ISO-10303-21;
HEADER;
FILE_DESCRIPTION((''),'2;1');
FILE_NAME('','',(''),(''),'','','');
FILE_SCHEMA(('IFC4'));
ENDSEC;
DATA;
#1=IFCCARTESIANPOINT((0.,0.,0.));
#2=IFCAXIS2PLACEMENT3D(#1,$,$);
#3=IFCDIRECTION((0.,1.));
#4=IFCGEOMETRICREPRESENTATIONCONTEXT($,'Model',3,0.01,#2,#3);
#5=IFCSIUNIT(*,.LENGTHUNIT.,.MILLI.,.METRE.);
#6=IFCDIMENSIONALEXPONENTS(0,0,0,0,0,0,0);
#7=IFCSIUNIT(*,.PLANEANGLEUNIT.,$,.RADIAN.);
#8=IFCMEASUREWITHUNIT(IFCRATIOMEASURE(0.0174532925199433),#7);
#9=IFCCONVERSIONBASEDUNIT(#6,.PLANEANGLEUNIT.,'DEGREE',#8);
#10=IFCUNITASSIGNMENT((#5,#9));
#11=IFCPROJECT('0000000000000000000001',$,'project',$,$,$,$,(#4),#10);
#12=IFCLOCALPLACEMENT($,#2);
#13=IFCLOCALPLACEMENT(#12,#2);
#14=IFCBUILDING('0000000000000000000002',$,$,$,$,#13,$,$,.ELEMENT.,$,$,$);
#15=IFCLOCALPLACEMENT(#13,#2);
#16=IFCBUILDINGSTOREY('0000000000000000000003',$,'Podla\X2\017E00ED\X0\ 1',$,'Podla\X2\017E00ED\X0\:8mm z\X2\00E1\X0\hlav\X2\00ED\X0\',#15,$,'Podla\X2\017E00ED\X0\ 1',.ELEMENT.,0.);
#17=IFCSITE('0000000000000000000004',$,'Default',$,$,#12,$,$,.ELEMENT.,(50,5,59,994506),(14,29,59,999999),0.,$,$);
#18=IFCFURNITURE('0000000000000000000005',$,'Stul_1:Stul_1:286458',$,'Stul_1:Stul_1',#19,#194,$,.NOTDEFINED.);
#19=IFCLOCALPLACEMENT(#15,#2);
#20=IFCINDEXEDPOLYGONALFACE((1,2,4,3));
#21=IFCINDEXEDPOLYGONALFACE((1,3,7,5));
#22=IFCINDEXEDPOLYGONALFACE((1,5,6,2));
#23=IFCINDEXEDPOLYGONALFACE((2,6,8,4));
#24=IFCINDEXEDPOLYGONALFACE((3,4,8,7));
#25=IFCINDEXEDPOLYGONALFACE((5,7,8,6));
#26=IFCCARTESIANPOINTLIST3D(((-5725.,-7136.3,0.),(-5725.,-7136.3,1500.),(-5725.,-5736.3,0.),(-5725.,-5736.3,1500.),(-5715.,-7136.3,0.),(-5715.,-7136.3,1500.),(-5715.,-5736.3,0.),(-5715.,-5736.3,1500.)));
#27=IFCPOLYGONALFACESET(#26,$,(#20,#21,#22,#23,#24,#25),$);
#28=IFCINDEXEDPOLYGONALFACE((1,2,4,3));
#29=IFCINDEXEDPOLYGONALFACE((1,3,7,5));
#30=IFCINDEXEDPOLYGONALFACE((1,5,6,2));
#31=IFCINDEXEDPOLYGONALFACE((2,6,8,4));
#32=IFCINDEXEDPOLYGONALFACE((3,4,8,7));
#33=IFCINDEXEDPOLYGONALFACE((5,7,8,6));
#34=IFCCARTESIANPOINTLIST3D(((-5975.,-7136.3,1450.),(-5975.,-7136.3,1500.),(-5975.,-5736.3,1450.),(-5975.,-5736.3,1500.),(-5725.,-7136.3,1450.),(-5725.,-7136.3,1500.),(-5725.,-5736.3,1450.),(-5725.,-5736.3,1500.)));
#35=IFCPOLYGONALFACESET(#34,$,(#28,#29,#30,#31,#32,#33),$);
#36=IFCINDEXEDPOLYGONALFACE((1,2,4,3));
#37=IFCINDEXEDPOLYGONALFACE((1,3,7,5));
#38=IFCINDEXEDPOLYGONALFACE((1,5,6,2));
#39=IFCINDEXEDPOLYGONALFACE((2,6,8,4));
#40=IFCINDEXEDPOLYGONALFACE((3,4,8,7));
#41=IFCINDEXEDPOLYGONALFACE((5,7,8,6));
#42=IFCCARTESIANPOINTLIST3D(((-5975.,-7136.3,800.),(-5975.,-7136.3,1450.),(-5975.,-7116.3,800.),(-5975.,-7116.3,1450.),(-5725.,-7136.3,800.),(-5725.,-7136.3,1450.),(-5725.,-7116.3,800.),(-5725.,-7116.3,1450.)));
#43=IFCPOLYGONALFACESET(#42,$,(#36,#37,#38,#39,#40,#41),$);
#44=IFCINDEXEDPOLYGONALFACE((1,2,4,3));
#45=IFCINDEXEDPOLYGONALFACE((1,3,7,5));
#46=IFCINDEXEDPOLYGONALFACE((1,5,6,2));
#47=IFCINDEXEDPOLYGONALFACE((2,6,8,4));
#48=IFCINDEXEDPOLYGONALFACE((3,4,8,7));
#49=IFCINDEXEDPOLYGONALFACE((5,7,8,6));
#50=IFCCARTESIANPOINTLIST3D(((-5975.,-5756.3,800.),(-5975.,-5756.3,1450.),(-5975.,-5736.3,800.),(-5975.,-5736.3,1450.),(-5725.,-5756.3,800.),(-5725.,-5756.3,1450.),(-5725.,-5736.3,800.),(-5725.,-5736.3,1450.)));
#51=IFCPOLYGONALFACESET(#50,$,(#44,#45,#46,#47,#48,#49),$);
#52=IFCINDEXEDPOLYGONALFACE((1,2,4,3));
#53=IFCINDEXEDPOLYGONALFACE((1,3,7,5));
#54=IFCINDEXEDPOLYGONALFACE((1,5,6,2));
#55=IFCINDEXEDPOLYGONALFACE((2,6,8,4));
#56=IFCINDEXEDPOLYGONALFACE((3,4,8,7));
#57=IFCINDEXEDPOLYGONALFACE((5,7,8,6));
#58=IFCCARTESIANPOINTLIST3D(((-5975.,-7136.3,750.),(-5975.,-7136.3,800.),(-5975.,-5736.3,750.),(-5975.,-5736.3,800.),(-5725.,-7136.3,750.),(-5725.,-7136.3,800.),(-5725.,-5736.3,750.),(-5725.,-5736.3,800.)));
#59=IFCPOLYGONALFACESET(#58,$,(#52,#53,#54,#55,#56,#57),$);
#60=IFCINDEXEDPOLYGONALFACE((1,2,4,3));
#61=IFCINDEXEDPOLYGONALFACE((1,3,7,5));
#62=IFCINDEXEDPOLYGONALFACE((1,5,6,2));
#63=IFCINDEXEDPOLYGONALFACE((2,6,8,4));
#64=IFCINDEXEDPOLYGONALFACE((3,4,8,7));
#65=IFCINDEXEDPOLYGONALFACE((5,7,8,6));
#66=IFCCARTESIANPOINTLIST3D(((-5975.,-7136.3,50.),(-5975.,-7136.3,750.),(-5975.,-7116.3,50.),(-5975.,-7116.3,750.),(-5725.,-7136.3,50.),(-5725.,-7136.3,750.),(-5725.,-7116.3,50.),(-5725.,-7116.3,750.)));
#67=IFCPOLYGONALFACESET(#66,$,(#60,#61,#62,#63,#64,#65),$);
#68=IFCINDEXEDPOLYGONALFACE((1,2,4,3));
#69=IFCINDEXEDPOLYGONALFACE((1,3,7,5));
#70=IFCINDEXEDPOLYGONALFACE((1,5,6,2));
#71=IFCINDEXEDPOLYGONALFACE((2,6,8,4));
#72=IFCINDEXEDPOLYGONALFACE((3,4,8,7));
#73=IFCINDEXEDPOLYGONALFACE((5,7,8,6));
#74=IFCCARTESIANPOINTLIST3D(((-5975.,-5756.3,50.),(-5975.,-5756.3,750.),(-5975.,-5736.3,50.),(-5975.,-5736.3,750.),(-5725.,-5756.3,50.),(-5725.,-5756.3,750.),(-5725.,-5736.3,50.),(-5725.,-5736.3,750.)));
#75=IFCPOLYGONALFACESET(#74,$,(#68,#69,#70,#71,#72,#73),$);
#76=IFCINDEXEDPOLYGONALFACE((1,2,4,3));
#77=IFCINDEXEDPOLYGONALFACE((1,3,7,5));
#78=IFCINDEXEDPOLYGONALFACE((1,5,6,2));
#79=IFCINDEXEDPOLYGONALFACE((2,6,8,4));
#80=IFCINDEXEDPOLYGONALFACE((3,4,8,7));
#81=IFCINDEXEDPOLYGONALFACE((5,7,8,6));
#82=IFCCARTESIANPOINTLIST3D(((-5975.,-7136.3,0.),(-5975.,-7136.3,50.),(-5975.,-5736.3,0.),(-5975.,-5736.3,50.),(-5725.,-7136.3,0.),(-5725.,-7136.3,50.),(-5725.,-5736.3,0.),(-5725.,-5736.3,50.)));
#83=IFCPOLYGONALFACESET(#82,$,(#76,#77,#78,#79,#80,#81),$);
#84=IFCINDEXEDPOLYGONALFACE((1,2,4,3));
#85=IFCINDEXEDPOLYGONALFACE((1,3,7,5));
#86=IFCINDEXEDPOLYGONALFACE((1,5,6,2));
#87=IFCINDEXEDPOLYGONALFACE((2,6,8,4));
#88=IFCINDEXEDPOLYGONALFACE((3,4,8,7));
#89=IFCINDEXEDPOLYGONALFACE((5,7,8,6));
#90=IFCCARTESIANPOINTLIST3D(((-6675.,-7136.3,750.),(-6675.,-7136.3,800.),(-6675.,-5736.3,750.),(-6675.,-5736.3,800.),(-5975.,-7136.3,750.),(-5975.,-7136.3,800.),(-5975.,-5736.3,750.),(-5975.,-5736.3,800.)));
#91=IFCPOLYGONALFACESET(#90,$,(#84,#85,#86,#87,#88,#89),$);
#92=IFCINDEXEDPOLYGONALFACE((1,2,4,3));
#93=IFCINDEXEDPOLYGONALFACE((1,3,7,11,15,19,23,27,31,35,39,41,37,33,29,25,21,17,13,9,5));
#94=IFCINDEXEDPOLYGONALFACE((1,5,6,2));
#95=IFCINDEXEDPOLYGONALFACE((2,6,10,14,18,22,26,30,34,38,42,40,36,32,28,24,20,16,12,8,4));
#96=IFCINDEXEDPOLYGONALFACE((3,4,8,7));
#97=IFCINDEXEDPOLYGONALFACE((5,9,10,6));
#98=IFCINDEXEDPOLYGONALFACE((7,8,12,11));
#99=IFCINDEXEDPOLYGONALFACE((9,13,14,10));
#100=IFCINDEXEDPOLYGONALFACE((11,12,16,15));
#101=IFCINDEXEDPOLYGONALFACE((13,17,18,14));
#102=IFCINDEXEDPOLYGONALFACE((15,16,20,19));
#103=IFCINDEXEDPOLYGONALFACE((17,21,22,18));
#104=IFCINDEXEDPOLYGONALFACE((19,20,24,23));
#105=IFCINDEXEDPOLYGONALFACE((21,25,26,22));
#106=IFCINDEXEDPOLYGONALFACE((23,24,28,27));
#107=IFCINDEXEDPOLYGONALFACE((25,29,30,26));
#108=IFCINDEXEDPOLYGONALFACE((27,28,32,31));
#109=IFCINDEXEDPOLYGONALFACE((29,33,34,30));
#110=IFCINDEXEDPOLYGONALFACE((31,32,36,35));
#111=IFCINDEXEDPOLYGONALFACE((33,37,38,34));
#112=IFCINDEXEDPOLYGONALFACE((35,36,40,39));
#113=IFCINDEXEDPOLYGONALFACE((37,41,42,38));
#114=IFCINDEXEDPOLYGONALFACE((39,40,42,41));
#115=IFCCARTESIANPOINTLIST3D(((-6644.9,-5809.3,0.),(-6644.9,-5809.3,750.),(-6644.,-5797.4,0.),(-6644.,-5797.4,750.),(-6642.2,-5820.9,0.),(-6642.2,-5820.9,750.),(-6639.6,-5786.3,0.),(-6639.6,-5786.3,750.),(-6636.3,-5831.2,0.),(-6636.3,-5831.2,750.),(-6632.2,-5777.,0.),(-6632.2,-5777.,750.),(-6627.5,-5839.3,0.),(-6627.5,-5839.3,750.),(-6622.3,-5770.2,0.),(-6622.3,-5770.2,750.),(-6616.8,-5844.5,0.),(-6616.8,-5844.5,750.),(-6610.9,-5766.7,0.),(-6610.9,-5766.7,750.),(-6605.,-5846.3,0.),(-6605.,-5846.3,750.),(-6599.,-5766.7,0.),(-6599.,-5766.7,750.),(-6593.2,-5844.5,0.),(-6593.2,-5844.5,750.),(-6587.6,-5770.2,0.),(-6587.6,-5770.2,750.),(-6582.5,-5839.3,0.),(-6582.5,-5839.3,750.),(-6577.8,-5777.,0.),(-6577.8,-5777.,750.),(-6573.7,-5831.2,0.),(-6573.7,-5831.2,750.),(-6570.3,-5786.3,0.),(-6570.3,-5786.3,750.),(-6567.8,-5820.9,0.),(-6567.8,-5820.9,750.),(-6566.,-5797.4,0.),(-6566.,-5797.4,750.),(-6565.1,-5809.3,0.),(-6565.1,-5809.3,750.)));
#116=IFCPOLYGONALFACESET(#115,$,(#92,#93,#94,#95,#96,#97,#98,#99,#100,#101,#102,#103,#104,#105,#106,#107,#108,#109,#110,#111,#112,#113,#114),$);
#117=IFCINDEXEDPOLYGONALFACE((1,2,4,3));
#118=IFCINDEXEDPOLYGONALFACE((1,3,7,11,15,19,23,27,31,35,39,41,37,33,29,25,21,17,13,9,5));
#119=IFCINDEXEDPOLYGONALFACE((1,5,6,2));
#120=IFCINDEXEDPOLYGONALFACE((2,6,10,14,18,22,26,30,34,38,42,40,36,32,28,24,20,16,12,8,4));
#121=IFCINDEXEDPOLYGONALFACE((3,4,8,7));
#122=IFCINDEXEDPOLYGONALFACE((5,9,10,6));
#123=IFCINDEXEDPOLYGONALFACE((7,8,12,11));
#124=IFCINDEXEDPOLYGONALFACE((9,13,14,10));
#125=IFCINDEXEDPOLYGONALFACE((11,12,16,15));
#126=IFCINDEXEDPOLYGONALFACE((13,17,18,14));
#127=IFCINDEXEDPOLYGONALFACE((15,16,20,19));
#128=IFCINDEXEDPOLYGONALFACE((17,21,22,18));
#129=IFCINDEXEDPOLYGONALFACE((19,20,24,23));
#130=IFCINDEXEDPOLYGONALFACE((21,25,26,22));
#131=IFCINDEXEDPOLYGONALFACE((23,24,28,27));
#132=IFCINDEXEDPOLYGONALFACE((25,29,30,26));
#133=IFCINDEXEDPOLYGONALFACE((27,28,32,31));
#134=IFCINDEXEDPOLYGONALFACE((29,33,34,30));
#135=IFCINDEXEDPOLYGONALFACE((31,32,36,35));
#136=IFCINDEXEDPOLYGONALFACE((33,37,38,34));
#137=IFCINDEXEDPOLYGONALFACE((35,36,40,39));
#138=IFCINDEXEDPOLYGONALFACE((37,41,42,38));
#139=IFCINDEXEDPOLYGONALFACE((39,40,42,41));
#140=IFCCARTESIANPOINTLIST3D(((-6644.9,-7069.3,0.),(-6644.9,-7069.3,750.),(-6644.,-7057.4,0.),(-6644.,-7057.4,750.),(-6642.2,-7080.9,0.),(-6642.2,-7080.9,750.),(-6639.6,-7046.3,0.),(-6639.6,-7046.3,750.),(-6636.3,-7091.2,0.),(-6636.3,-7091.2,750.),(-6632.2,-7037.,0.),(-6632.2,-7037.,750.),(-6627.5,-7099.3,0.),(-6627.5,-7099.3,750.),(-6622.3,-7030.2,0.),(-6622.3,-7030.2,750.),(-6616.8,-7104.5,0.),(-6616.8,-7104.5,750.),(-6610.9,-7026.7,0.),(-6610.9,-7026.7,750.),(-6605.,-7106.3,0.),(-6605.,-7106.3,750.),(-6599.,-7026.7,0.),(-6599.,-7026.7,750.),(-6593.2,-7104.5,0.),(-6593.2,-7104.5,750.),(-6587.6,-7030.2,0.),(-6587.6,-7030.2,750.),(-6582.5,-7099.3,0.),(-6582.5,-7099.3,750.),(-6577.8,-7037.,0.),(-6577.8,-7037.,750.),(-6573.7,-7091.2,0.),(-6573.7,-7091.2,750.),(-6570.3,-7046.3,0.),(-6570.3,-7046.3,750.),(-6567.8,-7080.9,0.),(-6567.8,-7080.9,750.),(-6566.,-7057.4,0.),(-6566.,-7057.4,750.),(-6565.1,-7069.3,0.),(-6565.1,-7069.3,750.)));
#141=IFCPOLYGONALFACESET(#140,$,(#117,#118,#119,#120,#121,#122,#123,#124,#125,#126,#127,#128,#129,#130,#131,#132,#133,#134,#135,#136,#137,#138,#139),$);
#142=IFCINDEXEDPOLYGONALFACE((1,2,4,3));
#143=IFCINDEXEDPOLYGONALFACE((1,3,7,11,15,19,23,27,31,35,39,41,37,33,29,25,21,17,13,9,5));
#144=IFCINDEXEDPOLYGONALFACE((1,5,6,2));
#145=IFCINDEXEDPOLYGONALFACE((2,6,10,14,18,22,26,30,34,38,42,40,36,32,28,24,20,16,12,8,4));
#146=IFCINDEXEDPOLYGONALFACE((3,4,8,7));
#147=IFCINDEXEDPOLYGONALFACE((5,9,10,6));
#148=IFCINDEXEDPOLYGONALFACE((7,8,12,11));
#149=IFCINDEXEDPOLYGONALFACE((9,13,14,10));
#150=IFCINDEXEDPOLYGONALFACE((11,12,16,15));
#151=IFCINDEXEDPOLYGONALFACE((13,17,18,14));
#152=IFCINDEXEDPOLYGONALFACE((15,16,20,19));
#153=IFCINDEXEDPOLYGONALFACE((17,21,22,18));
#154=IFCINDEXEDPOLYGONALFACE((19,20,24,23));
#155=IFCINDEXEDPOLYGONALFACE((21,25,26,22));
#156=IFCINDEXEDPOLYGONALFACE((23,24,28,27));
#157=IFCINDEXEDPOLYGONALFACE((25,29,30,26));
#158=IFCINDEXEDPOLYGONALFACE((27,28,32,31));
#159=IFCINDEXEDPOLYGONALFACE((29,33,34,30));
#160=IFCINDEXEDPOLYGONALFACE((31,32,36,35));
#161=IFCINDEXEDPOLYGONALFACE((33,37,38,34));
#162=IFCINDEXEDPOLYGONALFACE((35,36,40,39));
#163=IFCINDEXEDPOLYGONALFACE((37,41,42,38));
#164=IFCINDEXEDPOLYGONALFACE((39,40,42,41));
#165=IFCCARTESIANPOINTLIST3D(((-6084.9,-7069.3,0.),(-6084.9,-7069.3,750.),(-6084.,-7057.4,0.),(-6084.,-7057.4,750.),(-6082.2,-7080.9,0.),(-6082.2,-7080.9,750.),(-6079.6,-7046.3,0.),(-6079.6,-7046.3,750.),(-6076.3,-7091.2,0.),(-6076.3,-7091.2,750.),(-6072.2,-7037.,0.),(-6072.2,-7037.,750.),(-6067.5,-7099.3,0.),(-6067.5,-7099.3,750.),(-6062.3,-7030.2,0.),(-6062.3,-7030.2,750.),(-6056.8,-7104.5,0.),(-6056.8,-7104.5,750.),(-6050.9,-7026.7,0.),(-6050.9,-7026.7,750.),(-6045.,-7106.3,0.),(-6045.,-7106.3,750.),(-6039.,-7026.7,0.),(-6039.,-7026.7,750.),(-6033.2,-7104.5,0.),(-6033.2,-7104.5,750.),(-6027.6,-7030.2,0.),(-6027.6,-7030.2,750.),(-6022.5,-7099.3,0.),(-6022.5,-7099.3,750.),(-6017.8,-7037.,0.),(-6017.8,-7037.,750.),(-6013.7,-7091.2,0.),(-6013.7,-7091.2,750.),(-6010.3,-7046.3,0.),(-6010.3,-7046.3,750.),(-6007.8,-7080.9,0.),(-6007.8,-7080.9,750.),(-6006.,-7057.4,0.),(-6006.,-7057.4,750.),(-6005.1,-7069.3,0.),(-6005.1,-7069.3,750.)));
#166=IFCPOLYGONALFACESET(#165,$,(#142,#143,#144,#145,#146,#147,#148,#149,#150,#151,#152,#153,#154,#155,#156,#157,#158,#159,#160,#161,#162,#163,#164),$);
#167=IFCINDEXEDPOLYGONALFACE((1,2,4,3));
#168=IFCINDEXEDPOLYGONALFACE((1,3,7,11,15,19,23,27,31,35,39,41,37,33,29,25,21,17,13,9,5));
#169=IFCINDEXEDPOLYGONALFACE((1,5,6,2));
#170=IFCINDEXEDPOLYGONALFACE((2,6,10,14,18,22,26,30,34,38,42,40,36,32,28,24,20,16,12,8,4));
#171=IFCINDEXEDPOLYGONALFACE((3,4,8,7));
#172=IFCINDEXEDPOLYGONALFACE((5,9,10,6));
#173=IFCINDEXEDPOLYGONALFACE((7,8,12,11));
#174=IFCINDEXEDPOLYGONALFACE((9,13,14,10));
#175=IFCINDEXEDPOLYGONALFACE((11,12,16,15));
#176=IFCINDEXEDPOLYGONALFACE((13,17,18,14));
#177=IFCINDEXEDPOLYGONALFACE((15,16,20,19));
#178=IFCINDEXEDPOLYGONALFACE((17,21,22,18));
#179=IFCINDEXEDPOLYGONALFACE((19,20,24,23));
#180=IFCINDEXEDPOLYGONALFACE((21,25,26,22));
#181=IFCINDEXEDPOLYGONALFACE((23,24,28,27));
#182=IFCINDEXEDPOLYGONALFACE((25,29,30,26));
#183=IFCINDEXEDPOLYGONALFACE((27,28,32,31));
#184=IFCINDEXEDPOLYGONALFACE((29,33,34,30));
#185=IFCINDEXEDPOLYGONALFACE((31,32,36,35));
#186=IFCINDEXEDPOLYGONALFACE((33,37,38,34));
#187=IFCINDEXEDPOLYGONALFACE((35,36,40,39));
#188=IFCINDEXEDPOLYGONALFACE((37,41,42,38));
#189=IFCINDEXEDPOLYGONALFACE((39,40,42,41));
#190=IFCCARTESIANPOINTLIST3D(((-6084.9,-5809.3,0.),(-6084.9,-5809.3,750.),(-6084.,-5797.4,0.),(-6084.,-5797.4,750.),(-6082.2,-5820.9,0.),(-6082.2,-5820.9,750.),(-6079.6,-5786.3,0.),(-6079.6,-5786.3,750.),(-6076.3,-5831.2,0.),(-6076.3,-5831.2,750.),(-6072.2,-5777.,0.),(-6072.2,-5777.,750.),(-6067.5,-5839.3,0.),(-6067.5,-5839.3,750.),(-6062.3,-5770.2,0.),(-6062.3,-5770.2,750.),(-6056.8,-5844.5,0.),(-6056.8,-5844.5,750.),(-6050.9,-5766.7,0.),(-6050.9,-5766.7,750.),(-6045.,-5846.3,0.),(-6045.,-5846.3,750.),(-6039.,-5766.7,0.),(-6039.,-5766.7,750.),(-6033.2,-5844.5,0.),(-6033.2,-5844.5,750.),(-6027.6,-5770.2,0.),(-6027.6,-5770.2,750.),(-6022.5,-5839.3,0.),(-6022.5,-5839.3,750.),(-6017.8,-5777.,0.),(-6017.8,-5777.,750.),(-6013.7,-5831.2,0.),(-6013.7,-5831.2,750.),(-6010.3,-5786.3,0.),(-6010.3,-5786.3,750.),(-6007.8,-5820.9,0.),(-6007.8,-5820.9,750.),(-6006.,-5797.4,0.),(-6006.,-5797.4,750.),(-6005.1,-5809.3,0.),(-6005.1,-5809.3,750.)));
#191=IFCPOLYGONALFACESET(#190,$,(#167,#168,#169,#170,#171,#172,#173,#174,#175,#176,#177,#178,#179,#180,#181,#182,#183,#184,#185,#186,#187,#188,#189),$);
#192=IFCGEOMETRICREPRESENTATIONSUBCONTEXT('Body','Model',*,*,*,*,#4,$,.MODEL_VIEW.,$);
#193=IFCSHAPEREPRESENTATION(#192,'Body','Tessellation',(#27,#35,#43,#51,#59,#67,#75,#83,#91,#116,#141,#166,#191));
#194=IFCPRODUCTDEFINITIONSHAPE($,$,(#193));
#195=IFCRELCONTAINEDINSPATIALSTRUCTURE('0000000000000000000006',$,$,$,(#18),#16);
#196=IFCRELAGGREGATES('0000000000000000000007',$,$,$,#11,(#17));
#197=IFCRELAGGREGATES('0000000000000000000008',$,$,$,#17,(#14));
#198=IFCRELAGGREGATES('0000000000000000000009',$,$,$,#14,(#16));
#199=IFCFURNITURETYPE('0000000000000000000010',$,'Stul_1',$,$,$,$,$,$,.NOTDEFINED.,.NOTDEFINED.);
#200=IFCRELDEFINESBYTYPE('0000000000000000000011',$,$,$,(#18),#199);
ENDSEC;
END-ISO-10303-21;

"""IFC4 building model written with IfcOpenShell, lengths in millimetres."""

from ifc_helpers import new_model, entity, si_unit, converted_unit, direction, frame, frame_2d, origin, origin_2d_with_axis, place, context, subcontext, project, spatial, rectangle, circle, extrude, source, transform, mapped, type_object, type_shapes, element, save


model = new_model("IFC4")

# Units and contexts
model_context = context("Model", 3, precision=0.01, world=origin(), true_north=direction((0.0, 1.0)))
body_context = subcontext(model_context, "Body", "Model", "MODEL_VIEW")
ifc_project = project(units=[si_unit("LENGTHUNIT", "METRE", prefix="MILLI"), converted_unit("PLANEANGLEUNIT", "DEGREE", entity("IfcRatioMeasure", 0.0174532925199433), si_unit("PLANEANGLEUNIT", "RADIAN"), dimensions=[0, 0, 0, 0, 0, 0, 0])], contexts=[model_context])

# Site, building, storey
site_placement = place(None, origin())
site = spatial("IfcSite", under=ifc_project, at=site_placement, Name="Default", CompositionType="ELEMENT", RefLatitude=(50, 5, 59, 994506), RefLongitude=(14, 29, 59, 999999), RefElevation=0.0)
building_placement = place(site_placement, origin())
building = spatial("IfcBuilding", under=site, at=building_placement, CompositionType="ELEMENT")
storey_placement = place(building_placement, origin())
storey = spatial("IfcBuildingStorey", under=building, at=storey_placement, Name="Podlaží 1", ObjectType="Podlaží:8mm záhlaví", LongName="Podlaží 1", CompositionType="ELEMENT", Elevation=0.0)

# Furniture
furniture_type = type_object("IfcFurnitureType", Name="Stul_1", AssemblyPlace="NOTDEFINED", PredefinedType="NOTDEFINED")
shared_shape_1 = source(origin(), body_context, "Body", "SweptSolid", [
    extrude(rectangle(XDim=1400.0, YDim=10.0, at=origin_2d_with_axis()), frame((0.0, 605.0, 0.0), z_axis=(0.0, 0.0, 1.0), x_axis=(-1.0, 0.0, 0.0)), (0.0, 0.0, 1.0), 1500.0),
    extrude(rectangle(XDim=1400.0, YDim=250.0, at=frame_2d((0.0, 0.0), x_axis=(1.0, 0.0))), frame((0.0, 475.0, 1450.0), z_axis=(0.0, 0.0, 1.0), x_axis=(-1.0, 0.0, 0.0)), (0.0, 0.0, 1.0), 50.0),
    extrude(rectangle(XDim=20.0, YDim=250.0, at=origin_2d_with_axis()), frame((690.0, 475.0, 800.0), z_axis=(0.0, 0.0, 1.0), x_axis=(-1.0, 0.0, 0.0)), (0.0, 0.0, 1.0), 650.0),
    extrude(rectangle(XDim=20.0, YDim=250.0, at=frame_2d((0.0, 0.0), x_axis=(1.0, 0.0))), frame((-690.0, 475.0, 800.0), z_axis=(0.0, 0.0, 1.0), x_axis=(-1.0, 0.0, 0.0)), (0.0, 0.0, 1.0), 650.0),
    extrude(rectangle(XDim=1400.0, YDim=250.0, at=origin_2d_with_axis()), frame((0.0, 475.0, 750.0), z_axis=(0.0, 0.0, 1.0), x_axis=(-1.0, 0.0, 0.0)), (0.0, 0.0, 1.0), 50.0),
    extrude(rectangle(XDim=20.0, YDim=250.0, at=origin_2d_with_axis()), frame((690.0, 475.0, 50.0), z_axis=(0.0, 0.0, 1.0), x_axis=(-1.0, 0.0, 0.0)), (0.0, 0.0, 1.0), 700.0),
    extrude(rectangle(XDim=20.0, YDim=250.0, at=frame_2d((0.0, 0.0), x_axis=(1.0, 0.0))), frame((-690.0, 475.0, 50.0), z_axis=(0.0, 0.0, 1.0), x_axis=(-1.0, 0.0, 0.0)), (0.0, 0.0, 1.0), 700.0),
    extrude(rectangle(XDim=1400.0, YDim=250.0, at=origin_2d_with_axis()), frame((0.0, 475.0, 0.0), z_axis=(0.0, 0.0, 1.0), x_axis=(-1.0, 0.0, 0.0)), (0.0, 0.0, 1.0), 50.0),
    extrude(rectangle(XDim=1400.0, YDim=700.0, at=origin_2d_with_axis()), frame((0.0, 0.0, 750.0), z_axis=(0.0, 0.0, 1.0), x_axis=(-1.0, 0.0, 0.0)), (0.0, 0.0, 1.0), 50.0),
    extrude(circle(Radius=40.0, at=frame_2d((0.0, 0.0), x_axis=(1.0, 0.0))), frame((-630.0, -280.0, 0.0)), (0.0, 0.0, 1.0), 750.0),
    extrude(circle(Radius=40.0, at=frame_2d((0.0, 0.0), x_axis=(1.0, 0.0))), frame((630.0, -280.0, 0.0)), (0.0, 0.0, 1.0), 750.0),
    extrude(circle(Radius=40.0, at=frame_2d((0.0, 0.0), x_axis=(1.0, 0.0))), frame((630.0, 280.0, 0.0)), (0.0, 0.0, 1.0), 750.0),
    extrude(circle(Radius=40.0, at=frame_2d((0.0, 0.0), x_axis=(1.0, 0.0))), frame((-630.0, 280.0, 0.0)), (0.0, 0.0, 1.0), 750.0),
])
type_shapes(furniture_type, [shared_shape_1])
for number, where, z_axis, x_axis, name in (
    (1, (-6325.0, -6436.3, 0.0), (0.0, 0.0, 1.0), (0.0, -1.0, 0.0), "Stul_1:Stul_1:286458"),
):
    element("IfcFurniture", number, at=place(storey_placement, frame(where, z_axis=z_axis, x_axis=x_axis)), inside=storey, type_object=furniture_type, Name=name, ObjectType="Stul_1:Stul_1", PredefinedType="NOTDEFINED", context=body_context, shape_type="MappedRepresentation", body=[
        mapped(shared_shape_1, transform((0.0, 0.0, 0.0), scale=1.0)),
    ])

save(model, "model.ifc")
